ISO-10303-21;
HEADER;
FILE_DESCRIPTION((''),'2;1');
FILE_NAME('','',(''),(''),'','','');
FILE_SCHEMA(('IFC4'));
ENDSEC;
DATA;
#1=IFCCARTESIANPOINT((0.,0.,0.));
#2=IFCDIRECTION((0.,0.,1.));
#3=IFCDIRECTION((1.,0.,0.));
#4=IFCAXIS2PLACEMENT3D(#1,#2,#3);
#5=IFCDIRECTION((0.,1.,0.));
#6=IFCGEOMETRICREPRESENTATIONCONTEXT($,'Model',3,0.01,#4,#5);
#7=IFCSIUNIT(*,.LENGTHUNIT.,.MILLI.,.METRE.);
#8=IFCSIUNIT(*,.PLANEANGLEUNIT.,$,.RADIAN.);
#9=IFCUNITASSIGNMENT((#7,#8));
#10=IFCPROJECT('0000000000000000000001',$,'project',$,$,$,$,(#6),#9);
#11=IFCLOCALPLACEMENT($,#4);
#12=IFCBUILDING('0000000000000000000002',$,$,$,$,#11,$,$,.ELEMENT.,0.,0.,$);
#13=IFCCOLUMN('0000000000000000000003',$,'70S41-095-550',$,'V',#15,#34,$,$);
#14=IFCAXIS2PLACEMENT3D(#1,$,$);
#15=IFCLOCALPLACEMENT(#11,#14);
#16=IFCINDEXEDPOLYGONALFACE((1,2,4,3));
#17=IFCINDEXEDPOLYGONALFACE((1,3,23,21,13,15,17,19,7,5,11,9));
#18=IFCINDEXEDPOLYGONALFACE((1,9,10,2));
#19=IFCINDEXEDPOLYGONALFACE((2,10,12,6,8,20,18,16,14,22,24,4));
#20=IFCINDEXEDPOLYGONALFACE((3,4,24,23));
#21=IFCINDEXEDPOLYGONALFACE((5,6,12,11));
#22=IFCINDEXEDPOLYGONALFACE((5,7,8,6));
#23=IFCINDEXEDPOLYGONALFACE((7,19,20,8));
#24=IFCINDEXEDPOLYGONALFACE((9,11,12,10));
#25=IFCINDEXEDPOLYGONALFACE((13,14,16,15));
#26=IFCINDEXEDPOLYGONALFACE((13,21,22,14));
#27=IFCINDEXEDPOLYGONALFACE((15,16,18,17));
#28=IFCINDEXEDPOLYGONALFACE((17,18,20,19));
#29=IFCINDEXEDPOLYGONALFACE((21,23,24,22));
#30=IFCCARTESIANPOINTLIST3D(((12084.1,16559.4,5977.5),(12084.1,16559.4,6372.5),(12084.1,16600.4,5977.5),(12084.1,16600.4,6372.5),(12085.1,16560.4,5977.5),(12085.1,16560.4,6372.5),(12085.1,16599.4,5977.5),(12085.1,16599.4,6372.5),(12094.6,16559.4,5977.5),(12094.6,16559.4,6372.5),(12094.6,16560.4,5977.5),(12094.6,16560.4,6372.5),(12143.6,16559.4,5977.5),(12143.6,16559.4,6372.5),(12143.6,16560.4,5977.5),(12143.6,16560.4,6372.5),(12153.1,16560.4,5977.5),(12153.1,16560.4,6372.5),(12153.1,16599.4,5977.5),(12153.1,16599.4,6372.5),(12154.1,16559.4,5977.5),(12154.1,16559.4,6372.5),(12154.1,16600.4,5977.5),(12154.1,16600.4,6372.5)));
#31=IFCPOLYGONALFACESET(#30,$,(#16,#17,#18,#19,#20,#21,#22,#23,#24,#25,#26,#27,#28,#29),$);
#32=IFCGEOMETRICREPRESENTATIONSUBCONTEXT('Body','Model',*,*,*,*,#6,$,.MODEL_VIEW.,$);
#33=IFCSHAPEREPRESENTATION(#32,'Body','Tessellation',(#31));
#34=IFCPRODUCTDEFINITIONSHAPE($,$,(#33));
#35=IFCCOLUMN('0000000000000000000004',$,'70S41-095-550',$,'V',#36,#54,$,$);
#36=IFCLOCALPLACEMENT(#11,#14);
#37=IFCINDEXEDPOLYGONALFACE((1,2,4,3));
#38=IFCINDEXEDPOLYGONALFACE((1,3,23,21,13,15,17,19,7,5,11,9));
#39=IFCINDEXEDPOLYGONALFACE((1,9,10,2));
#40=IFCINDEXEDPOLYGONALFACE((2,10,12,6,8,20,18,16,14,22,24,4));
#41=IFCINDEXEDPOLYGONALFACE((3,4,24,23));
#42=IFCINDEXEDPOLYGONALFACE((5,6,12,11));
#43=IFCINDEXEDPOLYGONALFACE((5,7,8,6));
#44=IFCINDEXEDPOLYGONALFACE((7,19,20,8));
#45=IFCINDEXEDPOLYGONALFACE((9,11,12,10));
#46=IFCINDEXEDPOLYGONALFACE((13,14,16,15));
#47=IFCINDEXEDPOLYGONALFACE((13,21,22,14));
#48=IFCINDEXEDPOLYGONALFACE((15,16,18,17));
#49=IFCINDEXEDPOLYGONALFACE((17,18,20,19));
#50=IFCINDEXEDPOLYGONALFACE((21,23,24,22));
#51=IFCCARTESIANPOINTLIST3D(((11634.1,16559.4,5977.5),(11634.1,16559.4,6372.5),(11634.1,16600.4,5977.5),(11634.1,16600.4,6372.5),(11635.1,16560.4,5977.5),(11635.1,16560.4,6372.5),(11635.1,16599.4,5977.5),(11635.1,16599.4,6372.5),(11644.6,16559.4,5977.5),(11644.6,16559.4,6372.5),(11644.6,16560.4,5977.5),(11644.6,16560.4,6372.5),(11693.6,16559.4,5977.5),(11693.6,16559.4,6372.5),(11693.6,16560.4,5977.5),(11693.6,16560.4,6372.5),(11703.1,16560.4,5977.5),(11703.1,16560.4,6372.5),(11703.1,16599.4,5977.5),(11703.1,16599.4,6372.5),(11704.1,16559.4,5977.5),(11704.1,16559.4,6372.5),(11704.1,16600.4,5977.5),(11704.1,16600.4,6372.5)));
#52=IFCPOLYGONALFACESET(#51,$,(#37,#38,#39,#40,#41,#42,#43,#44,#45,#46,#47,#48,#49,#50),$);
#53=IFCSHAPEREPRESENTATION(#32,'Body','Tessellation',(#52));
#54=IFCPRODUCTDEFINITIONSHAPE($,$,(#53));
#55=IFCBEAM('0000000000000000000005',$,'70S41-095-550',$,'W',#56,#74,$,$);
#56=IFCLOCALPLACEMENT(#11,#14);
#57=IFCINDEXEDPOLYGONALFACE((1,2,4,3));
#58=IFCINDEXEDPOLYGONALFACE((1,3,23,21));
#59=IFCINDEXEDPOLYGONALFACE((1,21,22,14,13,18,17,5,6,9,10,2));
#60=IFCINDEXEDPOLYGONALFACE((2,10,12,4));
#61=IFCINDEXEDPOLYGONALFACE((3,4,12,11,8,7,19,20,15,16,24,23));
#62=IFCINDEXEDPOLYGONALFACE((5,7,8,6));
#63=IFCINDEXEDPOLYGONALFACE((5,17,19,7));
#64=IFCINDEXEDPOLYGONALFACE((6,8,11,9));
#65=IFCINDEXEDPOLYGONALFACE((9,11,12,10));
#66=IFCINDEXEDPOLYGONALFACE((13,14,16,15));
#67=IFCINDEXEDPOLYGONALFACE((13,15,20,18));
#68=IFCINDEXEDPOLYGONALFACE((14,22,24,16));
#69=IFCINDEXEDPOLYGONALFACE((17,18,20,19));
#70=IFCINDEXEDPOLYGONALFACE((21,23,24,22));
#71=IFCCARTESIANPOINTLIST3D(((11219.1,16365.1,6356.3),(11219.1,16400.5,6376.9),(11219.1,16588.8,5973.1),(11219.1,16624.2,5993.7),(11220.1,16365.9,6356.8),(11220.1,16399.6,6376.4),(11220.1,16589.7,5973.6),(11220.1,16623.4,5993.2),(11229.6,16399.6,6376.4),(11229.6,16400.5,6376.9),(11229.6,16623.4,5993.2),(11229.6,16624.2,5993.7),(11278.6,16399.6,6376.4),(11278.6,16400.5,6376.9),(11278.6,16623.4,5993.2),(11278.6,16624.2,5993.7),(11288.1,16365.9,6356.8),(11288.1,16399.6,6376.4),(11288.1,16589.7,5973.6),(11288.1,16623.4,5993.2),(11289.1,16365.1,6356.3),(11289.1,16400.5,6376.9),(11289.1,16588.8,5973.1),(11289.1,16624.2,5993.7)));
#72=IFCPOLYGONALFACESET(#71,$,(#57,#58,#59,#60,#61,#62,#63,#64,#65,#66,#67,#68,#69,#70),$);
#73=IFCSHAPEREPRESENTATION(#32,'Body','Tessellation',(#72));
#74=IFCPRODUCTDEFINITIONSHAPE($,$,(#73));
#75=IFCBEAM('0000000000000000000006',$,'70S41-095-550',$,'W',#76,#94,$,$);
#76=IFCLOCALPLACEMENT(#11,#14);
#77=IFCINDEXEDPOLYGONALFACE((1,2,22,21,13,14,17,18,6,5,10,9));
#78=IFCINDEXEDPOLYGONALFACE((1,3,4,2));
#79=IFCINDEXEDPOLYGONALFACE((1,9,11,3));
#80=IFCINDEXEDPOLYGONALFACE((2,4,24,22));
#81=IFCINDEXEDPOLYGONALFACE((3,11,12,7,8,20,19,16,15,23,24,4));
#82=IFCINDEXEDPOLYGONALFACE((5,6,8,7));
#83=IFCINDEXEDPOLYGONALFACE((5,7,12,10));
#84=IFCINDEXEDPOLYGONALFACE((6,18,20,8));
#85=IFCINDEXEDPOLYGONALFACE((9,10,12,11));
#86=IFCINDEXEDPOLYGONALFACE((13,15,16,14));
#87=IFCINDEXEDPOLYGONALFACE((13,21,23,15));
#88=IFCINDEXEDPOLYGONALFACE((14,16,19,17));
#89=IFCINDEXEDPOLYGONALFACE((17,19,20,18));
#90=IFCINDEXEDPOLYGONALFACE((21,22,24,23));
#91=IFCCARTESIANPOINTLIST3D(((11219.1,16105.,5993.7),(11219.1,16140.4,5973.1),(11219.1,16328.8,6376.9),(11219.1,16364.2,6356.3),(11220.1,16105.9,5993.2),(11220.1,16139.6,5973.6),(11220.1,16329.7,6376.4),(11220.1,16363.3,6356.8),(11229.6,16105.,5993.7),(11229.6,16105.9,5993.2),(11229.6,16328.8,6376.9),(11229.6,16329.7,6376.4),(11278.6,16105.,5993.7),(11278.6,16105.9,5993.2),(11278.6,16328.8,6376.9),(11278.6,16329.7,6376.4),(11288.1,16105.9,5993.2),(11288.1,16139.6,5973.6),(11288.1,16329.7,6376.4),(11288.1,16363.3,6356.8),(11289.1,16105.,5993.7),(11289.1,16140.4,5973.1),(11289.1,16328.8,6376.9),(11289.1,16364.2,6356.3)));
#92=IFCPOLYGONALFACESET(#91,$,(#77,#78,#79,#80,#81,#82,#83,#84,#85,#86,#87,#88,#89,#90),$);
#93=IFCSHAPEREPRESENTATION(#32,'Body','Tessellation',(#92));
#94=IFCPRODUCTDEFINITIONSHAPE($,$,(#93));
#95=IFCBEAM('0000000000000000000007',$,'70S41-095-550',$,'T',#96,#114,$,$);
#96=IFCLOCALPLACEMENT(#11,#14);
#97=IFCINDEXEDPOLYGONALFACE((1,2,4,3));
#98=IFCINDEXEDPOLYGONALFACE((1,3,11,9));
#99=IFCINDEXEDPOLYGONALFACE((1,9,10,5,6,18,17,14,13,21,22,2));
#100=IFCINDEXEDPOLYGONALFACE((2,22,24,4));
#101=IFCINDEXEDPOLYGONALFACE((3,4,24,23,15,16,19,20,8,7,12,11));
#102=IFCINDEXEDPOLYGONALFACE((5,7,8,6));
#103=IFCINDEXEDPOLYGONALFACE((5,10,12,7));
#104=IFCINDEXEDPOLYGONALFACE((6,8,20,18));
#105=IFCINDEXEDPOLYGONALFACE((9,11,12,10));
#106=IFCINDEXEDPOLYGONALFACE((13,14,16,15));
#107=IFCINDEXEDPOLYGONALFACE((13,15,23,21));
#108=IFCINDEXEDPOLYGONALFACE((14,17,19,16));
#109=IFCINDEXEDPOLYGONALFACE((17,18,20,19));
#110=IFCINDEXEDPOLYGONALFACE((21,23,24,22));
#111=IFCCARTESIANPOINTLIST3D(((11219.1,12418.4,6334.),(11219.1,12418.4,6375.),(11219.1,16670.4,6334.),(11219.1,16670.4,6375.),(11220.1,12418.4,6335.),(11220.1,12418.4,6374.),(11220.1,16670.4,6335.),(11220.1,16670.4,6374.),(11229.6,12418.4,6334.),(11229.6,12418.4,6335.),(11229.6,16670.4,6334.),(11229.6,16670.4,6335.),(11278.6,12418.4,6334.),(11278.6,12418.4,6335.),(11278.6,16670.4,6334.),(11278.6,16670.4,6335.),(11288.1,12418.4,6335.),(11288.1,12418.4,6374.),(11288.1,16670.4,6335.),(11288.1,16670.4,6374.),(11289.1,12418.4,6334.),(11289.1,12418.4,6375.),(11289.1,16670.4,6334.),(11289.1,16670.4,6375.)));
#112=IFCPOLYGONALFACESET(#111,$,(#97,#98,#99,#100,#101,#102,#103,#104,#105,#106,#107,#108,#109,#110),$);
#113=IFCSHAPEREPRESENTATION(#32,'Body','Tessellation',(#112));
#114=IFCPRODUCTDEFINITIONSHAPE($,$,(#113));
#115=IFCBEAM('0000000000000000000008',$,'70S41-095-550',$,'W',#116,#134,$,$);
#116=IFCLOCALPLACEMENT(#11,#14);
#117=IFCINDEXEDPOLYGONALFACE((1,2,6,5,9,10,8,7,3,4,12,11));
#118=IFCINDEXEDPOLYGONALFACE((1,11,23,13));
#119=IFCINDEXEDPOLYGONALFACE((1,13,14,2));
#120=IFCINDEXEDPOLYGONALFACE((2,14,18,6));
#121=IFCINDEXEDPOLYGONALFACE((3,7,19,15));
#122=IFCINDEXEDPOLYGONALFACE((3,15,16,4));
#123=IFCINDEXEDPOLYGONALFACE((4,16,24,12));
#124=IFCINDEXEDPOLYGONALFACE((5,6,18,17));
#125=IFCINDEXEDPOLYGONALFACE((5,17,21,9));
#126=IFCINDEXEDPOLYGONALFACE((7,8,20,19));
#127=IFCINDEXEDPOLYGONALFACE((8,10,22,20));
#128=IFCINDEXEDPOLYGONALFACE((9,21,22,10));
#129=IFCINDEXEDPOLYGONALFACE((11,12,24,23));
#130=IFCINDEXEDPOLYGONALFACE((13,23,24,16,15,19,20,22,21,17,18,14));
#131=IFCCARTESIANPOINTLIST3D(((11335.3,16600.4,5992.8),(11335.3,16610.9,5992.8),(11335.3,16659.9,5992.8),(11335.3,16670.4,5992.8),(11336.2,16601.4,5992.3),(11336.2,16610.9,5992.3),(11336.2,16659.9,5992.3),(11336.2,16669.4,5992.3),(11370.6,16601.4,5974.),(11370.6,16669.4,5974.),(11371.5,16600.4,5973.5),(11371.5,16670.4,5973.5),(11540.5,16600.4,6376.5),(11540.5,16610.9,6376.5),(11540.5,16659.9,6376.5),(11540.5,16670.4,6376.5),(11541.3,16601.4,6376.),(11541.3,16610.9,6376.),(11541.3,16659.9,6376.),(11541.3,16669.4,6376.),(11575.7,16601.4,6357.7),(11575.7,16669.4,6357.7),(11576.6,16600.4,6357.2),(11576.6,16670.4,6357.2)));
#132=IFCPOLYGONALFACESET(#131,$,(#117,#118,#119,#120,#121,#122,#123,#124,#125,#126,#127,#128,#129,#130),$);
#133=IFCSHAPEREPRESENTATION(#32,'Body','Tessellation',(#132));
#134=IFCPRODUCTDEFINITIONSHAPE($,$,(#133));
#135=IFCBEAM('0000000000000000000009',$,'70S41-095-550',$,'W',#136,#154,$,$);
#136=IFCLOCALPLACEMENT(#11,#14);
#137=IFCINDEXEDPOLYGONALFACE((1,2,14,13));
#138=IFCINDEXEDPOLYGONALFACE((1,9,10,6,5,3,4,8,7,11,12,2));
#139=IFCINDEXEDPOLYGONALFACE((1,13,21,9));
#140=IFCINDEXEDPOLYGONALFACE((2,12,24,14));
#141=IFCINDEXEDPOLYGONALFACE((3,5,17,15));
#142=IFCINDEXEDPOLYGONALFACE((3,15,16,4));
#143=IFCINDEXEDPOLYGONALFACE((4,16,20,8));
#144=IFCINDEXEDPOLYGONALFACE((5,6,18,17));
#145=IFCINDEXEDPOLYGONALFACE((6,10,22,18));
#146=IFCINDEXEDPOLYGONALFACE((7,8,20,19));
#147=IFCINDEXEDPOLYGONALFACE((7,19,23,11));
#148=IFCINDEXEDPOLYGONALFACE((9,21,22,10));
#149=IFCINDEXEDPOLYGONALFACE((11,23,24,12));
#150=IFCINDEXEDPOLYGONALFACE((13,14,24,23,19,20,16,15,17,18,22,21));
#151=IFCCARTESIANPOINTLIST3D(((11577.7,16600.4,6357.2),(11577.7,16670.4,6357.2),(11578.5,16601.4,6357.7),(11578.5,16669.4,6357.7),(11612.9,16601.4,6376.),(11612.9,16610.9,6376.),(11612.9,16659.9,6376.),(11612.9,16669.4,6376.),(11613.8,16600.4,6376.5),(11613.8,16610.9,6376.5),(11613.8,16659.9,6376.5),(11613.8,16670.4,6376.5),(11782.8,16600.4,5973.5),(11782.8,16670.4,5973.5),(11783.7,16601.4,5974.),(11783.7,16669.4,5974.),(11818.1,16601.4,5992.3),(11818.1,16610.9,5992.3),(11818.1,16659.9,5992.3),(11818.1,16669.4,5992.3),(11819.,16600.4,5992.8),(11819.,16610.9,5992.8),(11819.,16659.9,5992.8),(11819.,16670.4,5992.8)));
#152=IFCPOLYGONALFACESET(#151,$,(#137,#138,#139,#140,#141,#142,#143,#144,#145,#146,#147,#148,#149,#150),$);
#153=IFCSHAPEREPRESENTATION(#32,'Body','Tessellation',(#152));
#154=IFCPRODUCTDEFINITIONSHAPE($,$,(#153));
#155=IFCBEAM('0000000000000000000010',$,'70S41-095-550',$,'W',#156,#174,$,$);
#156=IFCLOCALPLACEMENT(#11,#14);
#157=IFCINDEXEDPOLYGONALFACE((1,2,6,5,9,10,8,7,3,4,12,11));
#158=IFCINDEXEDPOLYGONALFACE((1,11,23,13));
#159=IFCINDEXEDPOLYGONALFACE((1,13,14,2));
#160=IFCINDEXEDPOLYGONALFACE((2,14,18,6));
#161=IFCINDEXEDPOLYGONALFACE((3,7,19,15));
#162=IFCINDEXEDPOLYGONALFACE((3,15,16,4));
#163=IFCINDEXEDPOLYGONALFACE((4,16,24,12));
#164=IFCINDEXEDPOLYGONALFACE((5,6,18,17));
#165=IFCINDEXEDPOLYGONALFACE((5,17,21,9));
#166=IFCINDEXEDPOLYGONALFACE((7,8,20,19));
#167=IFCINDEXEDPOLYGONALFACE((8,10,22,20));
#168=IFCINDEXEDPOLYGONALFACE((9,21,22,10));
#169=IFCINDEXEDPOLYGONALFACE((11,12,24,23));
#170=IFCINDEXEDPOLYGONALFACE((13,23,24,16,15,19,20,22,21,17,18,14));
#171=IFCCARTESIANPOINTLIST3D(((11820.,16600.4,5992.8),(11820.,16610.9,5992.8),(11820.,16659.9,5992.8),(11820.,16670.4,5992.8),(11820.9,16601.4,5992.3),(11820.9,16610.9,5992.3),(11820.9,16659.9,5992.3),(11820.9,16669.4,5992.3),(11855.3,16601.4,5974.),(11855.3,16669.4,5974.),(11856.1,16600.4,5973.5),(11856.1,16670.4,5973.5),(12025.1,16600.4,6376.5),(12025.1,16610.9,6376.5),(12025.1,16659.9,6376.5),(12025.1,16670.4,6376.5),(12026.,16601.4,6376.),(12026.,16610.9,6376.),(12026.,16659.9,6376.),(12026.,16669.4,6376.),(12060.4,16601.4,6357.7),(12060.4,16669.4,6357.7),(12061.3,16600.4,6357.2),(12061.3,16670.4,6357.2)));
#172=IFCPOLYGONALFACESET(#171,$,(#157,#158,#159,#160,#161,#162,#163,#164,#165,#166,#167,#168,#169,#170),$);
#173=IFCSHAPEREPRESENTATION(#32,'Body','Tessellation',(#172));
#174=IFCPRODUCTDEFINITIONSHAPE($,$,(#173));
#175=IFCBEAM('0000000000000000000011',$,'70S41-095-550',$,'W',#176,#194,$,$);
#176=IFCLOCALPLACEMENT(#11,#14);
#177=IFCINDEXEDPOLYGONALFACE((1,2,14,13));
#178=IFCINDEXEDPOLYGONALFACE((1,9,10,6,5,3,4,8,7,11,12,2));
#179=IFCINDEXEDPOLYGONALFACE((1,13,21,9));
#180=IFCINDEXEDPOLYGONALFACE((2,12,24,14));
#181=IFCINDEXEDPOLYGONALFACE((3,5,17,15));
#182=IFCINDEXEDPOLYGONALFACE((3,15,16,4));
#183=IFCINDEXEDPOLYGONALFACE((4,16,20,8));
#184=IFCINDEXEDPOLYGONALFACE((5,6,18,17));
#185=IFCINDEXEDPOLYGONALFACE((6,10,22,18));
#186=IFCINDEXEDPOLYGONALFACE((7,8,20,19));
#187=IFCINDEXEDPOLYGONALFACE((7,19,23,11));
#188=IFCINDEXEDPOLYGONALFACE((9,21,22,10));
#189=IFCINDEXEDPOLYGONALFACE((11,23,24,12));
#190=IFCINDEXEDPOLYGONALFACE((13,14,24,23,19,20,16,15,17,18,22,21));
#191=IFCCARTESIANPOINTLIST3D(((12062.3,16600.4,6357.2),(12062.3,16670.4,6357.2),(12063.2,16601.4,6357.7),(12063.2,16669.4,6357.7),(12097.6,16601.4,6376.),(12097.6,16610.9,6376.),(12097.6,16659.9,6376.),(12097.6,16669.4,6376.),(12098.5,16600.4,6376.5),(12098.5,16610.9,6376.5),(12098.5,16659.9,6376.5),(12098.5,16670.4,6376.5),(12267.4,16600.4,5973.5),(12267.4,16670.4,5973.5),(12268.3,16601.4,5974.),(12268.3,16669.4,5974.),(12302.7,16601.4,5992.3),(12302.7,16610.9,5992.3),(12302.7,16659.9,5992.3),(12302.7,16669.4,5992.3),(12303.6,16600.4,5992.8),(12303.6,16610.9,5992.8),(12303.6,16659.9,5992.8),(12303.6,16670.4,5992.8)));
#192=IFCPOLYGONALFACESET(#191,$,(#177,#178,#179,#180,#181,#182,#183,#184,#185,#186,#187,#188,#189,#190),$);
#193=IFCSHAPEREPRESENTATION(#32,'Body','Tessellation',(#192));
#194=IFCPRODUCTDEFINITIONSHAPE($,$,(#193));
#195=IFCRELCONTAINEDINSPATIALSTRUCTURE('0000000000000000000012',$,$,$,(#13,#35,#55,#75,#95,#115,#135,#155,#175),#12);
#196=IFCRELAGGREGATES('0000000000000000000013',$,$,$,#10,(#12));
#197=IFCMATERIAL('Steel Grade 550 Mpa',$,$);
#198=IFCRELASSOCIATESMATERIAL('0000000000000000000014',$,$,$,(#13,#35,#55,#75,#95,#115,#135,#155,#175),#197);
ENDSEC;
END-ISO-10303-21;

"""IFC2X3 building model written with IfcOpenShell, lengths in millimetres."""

from ifc_helpers import new_model, si_unit, direction, frame, origin, origin_with_axes, origin_2d_with_axis, place, context, subcontext, project, spatial, c_section, extrude, source, transform, mapped, material, element, save


model = new_model("IFC2X3")

# Units and contexts
model_context = context("Model", 3, precision=0.01, world=origin_with_axes(), true_north=direction((0.0, 1.0, 0.0)))
body_context = subcontext(model_context, "Body", "Model", "MODEL_VIEW")
ifc_project = project(units=[si_unit("LENGTHUNIT", "METRE", prefix="MILLI"), si_unit("PLANEANGLEUNIT", "RADIAN")], contexts=[model_context])

# Building
building_placement = place(None, origin_with_axes())
building = spatial("IfcBuilding", under=ifc_project, at=building_placement, CompositionType="ELEMENT", ElevationOfRefHeight=0.0, ElevationOfTerrain=0.0)

# Columns
ifc_material = material(Name="Steel Grade 550 Mpa")
shared_shape_1 = source(origin(), body_context, "Body", "SweptSolid", [
    extrude(c_section(Depth=70.0, Width=41.0, WallThickness=1.0, Girth=10.5, at=origin_2d_with_axis()), origin_with_axes(), (0.0, 0.0, 1.0), 395.0),
])
column_1_placement = place(None, frame((12119.1, 16579.9, 5977.5), z_axis=(0.0, 0.0, 1.0), x_axis=(0.0, -1.0, 0.0)))
element("IfcColumn", 1, at=column_1_placement, inside=building, material=ifc_material, Name="70S41-095-550", ObjectType="V", context=body_context, shape_type="MappedRepresentation", body=[
    mapped(shared_shape_1, transform((0.0, 0.0, 0.0), scale=1.0)),
])
shared_shape_2 = source(origin(), body_context, "Body", "SweptSolid", [
    extrude(c_section(Depth=70.0, Width=41.0, WallThickness=1.0, Girth=10.5, at=origin_2d_with_axis()), origin_with_axes(), (0.0, 0.0, 1.0), 395.0),
])
column_2_placement = place(None, frame((11669.1, 16579.9, 5977.5), z_axis=(0.0, 0.0, 1.0), x_axis=(0.0, -1.0, 0.0)))
element("IfcColumn", 2, at=column_2_placement, inside=building, material=ifc_material, Name="70S41-095-550", ObjectType="V", context=body_context, shape_type="MappedRepresentation", body=[
    mapped(shared_shape_2, transform((0.0, 0.0, 0.0), scale=1.0)),
])

# Beams
shared_shape_3 = source(origin(), body_context, "Body", "SweptSolid", [
    extrude(c_section(Depth=70.0, Width=41.0, WallThickness=1.0, Girth=10.5, at=origin_2d_with_axis()), origin_with_axes(), (0.0, 0.0, 1.0), 443.7),
])
beam_1_placement = place(None, frame((11254.1, 16382.8, 6366.6), z_axis=(0.0, 0.504288, -0.863535), x_axis=(0.0, 0.863535, 0.504288)))
element("IfcBeam", 3, at=beam_1_placement, inside=building, material=ifc_material, Name="70S41-095-550", ObjectType="W", context=body_context, shape_type="MappedRepresentation", body=[
    mapped(shared_shape_3, transform((0.0, 0.0, 0.0), scale=1.0)),
])
shared_shape_4 = source(origin(), body_context, "Body", "SweptSolid", [
    extrude(c_section(Depth=70.0, Width=41.0, WallThickness=1.0, Girth=10.5, at=origin_2d_with_axis()), origin_with_axes(), (0.0, 0.0, 1.0), 443.7),
])
beam_2_placement = place(None, frame((11254.1, 16122.7, 5983.4), z_axis=(0.0, 0.504288, 0.863535), x_axis=(0.0, -0.863535, 0.504288)))
element("IfcBeam", 4, at=beam_2_placement, inside=building, material=ifc_material, Name="70S41-095-550", ObjectType="W", context=body_context, shape_type="MappedRepresentation", body=[
    mapped(shared_shape_4, transform((0.0, 0.0, 0.0), scale=1.0)),
])
shared_shape_5 = source(origin(), body_context, "Body", "SweptSolid", [
    extrude(c_section(Depth=70.0, Width=41.0, WallThickness=1.0, Girth=10.5, at=origin_2d_with_axis()), origin_with_axes(), (0.0, 0.0, 1.0), 4252.0),
])
beam_3_placement = place(None, frame((11254.1, 16670.4, 6354.5), z_axis=(0.0, -1.0, 0.0), x_axis=(0.0, 0.0, -1.0)))
element("IfcBeam", 5, at=beam_3_placement, inside=building, material=ifc_material, Name="70S41-095-550", ObjectType="T", context=body_context, shape_type="MappedRepresentation", body=[
    mapped(shared_shape_5, transform((0.0, 0.0, 0.0), scale=1.0)),
])
shared_shape_6 = source(origin(), body_context, "Body", "SweptSolid", [
    extrude(c_section(Depth=70.0, Width=41.0, WallThickness=1.0, Girth=10.5, at=origin_2d_with_axis()), origin_with_axes(), (0.0, 0.0, 1.0), 435.1),
])
beam_4_placement = place(None, frame((11558.5, 16635.4, 6366.8), z_axis=(-0.471488, 0.0, -0.881872), x_axis=(-0.881872, 0.0, 0.471488)))
element("IfcBeam", 6, at=beam_4_placement, inside=building, material=ifc_material, Name="70S41-095-550", ObjectType="W", context=body_context, shape_type="MappedRepresentation", body=[
    mapped(shared_shape_6, transform((0.0, 0.0, 0.0), scale=1.0)),
])
shared_shape_7 = source(origin(), body_context, "Body", "SweptSolid", [
    extrude(c_section(Depth=70.0, Width=41.0, WallThickness=1.0, Girth=10.5, at=origin_2d_with_axis()), origin_with_axes(), (0.0, 0.0, 1.0), 435.1),
])
beam_5_placement = place(None, frame((11800.9, 16635.4, 5983.2), z_axis=(-0.471488, 0.0, 0.881872), x_axis=(0.881872, 0.0, 0.471488)))
element("IfcBeam", 7, at=beam_5_placement, inside=building, material=ifc_material, Name="70S41-095-550", ObjectType="W", context=body_context, shape_type="MappedRepresentation", body=[
    mapped(shared_shape_7, transform((0.0, 0.0, 0.0), scale=1.0)),
])
shared_shape_8 = source(origin(), body_context, "Body", "SweptSolid", [
    extrude(c_section(Depth=70.0, Width=41.0, WallThickness=1.0, Girth=10.5, at=origin_2d_with_axis()), origin_with_axes(), (0.0, 0.0, 1.0), 435.1),
])
beam_6_placement = place(None, frame((12043.2, 16635.4, 6366.8), z_axis=(-0.471488, 0.0, -0.881872), x_axis=(-0.881872, 0.0, 0.471488)))
element("IfcBeam", 8, at=beam_6_placement, inside=building, material=ifc_material, Name="70S41-095-550", ObjectType="W", context=body_context, shape_type="MappedRepresentation", body=[
    mapped(shared_shape_8, transform((0.0, 0.0, 0.0), scale=1.0)),
])
shared_shape_9 = source(origin(), body_context, "Body", "SweptSolid", [
    extrude(c_section(Depth=70.0, Width=41.0, WallThickness=1.0, Girth=10.5, at=origin_2d_with_axis()), origin_with_axes(), (0.0, 0.0, 1.0), 435.1),
])
beam_7_placement = place(None, frame((12285.5, 16635.4, 5983.2), z_axis=(-0.471488, 0.0, 0.881872), x_axis=(0.881872, 0.0, 0.471488)))
element("IfcBeam", 9, at=beam_7_placement, inside=building, material=ifc_material, Name="70S41-095-550", ObjectType="W", context=body_context, shape_type="MappedRepresentation", body=[
    mapped(shared_shape_9, transform((0.0, 0.0, 0.0), scale=1.0)),
])

save(model, "model.ifc")
